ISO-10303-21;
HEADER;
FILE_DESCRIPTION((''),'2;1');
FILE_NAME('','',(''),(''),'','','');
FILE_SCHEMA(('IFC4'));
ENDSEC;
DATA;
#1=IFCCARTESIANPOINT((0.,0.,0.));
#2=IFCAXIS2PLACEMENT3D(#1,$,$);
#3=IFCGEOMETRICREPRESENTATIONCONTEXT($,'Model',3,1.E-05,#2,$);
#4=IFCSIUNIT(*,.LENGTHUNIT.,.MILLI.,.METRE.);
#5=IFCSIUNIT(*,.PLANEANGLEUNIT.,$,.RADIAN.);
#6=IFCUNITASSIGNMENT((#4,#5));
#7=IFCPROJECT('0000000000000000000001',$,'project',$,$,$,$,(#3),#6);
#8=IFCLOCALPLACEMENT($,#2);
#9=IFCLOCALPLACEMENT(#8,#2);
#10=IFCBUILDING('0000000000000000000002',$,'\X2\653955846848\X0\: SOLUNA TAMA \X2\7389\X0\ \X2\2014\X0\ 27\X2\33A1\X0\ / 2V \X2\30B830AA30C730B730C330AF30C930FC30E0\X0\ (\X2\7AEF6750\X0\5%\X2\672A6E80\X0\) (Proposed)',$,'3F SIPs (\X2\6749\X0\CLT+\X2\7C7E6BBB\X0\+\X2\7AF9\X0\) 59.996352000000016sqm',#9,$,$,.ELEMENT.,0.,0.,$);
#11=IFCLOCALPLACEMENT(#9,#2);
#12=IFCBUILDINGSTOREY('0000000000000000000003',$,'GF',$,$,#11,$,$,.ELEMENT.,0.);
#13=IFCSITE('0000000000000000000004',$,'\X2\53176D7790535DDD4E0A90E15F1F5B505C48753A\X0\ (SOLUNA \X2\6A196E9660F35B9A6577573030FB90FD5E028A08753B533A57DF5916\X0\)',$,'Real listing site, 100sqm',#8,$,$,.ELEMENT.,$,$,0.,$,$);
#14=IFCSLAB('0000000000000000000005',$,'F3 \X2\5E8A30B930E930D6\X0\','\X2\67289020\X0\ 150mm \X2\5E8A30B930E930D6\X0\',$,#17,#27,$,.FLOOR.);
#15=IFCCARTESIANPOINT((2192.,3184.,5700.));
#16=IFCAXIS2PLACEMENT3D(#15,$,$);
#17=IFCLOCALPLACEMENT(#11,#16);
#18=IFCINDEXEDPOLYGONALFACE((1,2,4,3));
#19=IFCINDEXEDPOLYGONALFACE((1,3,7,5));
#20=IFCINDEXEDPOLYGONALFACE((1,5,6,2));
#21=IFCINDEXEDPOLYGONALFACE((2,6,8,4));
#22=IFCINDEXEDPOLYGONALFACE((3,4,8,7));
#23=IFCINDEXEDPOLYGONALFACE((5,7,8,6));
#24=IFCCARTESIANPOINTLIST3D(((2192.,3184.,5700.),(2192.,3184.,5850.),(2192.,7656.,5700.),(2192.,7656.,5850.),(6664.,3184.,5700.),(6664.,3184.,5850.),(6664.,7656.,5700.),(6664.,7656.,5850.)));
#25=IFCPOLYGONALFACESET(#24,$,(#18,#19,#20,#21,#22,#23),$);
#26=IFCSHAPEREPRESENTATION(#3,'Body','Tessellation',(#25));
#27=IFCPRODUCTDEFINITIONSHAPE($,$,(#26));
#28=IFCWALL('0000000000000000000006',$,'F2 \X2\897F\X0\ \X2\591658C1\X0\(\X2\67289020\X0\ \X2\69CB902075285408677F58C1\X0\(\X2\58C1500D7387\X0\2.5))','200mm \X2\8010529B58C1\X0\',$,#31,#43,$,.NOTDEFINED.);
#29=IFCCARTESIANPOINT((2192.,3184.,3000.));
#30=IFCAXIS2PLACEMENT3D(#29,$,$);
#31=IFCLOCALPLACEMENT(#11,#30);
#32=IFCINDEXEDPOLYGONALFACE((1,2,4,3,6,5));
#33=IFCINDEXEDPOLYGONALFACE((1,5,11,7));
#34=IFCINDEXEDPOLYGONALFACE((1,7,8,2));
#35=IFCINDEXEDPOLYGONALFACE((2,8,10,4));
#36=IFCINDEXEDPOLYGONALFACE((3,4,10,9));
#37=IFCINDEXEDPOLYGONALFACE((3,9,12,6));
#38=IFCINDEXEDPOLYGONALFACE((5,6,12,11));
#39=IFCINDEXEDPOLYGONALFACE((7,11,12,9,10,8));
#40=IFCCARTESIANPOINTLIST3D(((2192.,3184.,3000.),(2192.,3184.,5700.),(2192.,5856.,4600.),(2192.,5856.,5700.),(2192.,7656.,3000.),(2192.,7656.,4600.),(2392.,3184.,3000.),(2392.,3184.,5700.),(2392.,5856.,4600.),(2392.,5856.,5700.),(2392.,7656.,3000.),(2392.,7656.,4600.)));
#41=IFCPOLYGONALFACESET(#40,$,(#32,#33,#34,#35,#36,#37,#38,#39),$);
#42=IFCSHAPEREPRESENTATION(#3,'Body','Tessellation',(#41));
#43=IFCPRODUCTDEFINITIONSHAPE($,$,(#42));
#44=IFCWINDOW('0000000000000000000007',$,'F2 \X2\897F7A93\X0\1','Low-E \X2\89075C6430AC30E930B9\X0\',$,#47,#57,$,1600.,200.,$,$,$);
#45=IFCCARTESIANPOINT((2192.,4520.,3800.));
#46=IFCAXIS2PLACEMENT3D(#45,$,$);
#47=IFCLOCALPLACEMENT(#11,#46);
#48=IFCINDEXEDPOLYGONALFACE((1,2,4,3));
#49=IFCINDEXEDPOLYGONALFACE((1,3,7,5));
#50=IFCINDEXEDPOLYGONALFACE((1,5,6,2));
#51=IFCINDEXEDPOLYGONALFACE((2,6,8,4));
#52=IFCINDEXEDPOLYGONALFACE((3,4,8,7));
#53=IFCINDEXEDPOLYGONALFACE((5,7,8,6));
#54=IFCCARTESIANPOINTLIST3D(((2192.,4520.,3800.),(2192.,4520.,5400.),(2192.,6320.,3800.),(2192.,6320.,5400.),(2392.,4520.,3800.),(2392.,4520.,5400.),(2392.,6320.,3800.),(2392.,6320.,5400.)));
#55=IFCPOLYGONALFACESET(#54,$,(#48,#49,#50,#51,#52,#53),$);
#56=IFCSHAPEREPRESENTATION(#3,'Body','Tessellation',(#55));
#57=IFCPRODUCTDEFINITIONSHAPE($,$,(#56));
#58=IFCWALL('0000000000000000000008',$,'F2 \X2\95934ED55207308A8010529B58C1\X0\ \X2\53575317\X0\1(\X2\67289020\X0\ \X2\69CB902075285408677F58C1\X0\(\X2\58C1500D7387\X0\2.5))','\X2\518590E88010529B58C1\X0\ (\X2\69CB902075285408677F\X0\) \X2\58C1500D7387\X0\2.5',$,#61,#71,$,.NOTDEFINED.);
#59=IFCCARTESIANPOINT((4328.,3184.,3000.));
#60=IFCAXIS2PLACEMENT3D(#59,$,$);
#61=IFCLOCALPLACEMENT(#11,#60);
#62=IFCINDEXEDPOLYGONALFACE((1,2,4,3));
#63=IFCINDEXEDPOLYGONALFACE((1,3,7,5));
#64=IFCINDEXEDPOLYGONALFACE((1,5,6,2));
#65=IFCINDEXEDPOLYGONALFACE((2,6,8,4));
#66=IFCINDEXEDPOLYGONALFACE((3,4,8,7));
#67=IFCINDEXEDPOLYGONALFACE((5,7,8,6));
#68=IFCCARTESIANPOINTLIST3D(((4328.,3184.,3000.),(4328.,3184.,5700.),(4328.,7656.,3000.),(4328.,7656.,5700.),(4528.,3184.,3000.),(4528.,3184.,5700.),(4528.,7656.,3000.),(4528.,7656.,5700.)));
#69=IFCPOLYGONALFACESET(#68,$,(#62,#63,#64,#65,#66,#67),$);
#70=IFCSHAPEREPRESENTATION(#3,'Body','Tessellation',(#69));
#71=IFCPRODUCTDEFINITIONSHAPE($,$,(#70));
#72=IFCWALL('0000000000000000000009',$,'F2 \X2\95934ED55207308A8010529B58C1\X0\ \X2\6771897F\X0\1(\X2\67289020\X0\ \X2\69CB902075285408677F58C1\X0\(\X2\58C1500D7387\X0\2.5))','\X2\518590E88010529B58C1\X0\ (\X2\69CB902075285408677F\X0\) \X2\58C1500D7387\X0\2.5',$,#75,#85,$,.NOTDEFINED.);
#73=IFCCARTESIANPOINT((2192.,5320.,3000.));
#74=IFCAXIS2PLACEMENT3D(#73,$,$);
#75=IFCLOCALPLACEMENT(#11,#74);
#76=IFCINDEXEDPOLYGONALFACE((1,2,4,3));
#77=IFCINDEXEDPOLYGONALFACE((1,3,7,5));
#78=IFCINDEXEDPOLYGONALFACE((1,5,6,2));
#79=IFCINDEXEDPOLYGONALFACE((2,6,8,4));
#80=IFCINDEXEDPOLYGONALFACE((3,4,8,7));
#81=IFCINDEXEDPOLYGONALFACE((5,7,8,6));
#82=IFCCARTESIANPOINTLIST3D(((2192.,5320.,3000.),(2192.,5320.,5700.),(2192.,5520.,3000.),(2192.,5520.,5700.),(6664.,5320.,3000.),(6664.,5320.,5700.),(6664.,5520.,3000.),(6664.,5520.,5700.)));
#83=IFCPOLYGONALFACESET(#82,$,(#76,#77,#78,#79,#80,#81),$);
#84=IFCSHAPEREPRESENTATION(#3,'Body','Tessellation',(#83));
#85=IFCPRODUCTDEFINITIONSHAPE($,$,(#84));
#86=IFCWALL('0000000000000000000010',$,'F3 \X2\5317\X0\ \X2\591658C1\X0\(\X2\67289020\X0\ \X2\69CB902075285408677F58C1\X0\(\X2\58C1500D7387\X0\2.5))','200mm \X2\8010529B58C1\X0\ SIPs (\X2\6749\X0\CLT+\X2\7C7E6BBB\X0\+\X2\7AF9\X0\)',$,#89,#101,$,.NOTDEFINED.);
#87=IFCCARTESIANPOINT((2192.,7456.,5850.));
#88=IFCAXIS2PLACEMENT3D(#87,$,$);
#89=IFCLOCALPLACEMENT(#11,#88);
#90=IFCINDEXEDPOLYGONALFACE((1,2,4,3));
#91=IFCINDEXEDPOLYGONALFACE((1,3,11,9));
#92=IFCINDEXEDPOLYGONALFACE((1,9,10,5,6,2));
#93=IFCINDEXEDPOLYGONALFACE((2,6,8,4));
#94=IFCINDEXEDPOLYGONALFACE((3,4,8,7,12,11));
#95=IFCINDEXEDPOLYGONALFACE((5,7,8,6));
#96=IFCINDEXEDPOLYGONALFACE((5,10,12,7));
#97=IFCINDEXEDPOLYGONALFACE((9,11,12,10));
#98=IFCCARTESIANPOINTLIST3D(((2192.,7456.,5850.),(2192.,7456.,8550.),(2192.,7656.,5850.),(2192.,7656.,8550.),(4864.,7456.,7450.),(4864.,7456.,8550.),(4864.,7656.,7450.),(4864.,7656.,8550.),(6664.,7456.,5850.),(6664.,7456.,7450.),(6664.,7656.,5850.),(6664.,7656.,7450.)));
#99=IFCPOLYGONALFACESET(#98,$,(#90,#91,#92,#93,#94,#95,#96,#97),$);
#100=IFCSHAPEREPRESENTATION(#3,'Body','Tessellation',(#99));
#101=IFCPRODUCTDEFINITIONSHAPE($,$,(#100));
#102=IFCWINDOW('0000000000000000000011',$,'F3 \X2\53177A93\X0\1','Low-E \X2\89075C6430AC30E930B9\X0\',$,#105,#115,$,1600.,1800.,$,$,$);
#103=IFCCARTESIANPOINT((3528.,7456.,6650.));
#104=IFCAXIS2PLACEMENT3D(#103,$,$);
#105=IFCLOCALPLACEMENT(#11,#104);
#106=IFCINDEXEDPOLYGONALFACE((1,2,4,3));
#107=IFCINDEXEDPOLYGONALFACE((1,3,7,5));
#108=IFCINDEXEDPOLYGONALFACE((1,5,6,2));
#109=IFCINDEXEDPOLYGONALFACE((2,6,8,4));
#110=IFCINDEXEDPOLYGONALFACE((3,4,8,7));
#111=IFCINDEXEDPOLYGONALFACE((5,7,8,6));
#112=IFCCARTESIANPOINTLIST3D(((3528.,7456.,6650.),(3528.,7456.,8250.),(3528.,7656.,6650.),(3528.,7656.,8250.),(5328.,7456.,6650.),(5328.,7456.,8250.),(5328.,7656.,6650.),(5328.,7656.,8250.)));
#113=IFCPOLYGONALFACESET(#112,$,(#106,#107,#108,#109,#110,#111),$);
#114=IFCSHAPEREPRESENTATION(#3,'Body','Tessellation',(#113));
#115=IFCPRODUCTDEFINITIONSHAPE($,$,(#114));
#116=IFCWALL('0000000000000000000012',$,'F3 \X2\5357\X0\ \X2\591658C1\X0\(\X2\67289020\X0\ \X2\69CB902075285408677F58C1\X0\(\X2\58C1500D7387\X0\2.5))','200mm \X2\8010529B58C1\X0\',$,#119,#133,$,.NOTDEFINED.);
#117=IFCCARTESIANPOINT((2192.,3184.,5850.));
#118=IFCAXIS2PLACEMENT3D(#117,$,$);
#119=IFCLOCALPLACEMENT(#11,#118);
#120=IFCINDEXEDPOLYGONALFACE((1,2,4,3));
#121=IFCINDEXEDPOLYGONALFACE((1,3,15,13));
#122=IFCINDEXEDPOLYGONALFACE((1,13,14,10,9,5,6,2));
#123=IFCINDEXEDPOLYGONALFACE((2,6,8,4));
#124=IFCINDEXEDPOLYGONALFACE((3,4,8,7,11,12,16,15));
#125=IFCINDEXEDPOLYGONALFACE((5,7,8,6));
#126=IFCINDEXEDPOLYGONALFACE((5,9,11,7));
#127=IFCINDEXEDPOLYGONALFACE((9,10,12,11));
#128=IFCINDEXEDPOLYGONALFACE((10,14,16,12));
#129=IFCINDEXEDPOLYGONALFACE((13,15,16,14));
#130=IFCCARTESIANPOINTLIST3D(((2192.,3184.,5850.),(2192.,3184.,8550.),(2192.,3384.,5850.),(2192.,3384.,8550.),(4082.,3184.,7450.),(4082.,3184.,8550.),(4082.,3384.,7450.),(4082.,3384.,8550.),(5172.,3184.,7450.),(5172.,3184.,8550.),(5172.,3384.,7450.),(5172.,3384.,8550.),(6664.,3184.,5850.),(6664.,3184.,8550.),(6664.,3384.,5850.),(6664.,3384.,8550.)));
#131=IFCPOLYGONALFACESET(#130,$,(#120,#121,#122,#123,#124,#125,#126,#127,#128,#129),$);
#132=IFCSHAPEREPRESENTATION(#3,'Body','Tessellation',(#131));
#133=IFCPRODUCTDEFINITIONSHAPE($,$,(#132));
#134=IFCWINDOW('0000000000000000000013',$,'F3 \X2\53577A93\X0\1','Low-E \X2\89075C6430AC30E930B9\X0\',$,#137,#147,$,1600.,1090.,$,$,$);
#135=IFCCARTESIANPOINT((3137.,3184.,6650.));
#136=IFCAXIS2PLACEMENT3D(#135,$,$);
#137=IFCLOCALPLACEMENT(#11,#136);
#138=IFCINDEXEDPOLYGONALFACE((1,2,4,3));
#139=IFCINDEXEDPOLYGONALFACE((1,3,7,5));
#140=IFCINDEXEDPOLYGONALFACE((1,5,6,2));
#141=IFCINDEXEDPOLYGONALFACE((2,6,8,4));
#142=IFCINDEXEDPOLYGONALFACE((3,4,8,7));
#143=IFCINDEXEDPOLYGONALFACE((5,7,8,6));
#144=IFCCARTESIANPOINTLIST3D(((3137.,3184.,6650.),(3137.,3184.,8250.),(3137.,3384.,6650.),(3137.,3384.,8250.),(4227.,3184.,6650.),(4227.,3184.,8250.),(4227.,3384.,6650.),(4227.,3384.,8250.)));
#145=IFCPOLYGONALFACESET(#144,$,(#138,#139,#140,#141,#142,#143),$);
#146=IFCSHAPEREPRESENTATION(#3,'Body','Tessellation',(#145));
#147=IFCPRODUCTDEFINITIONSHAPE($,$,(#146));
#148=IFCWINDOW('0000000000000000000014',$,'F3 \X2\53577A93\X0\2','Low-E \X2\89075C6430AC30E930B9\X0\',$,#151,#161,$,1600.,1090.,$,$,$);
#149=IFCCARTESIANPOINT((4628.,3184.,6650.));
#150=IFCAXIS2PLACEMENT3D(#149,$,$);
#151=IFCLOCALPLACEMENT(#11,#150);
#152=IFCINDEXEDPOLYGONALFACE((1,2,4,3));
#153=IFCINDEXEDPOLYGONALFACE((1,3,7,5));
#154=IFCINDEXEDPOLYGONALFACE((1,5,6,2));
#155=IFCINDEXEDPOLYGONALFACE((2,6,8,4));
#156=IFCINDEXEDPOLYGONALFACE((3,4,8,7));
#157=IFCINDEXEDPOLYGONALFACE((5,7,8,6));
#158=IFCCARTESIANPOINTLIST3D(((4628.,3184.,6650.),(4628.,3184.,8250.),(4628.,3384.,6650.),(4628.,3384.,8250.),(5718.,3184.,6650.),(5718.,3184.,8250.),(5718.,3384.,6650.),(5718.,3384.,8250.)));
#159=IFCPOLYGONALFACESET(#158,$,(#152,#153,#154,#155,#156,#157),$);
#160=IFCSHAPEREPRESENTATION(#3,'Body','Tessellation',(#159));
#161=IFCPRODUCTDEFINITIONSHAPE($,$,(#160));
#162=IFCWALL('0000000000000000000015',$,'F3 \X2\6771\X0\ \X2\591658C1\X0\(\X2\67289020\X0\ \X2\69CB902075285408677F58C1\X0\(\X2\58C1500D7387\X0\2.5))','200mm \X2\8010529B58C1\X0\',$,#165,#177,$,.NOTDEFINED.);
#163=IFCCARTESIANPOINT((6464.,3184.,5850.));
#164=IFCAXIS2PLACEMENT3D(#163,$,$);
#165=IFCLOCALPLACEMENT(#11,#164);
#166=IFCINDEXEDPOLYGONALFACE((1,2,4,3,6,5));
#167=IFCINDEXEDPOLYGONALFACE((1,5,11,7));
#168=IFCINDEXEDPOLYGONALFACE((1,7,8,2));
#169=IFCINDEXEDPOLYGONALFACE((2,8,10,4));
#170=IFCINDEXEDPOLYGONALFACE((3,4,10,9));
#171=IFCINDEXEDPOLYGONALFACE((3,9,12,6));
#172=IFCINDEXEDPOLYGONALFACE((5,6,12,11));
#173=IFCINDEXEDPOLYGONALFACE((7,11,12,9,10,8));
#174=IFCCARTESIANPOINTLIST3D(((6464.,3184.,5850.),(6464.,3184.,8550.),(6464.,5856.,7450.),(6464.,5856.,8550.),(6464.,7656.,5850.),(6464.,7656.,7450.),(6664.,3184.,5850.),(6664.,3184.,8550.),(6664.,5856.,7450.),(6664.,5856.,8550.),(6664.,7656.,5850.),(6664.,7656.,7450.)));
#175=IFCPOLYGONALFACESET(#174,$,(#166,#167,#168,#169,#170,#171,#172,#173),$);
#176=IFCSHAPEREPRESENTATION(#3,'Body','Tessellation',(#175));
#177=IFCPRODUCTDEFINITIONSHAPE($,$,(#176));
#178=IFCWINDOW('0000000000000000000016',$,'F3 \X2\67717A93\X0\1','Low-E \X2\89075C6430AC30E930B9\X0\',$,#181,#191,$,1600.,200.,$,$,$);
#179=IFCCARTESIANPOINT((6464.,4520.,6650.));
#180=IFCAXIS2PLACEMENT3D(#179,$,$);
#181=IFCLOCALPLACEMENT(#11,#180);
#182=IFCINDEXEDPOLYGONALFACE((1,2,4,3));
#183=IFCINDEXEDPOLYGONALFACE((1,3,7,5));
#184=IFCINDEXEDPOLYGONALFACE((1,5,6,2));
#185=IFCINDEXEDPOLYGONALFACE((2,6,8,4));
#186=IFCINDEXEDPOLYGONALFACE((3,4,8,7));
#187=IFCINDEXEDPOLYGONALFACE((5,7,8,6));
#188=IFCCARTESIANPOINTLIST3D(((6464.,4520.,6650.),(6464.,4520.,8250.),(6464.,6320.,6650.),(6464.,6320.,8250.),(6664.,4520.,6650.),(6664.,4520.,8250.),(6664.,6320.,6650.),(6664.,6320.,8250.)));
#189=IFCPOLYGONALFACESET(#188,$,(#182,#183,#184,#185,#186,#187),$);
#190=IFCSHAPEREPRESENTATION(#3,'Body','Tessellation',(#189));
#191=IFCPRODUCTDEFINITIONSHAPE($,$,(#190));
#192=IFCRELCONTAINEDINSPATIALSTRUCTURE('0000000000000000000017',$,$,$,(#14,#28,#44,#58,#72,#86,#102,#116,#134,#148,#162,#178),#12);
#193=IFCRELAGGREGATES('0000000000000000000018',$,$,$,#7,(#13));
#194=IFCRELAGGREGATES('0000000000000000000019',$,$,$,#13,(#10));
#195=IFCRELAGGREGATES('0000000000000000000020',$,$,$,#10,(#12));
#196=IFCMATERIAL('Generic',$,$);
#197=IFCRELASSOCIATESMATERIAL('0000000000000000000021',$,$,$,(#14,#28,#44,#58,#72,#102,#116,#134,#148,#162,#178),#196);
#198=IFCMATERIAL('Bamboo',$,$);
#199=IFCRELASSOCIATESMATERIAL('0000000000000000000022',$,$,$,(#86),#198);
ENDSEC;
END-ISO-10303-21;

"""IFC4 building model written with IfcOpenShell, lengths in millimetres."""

from ifc_helpers import new_model, si_unit, frame, frame_2d, origin, place, context, project, spatial, rectangle, extrude, material, element, fill, save


model = new_model("IFC4")

# Units and contexts
model_context = context("Model", 3, precision=1e-05, world=origin())
ifc_project = project(units=[si_unit("LENGTHUNIT", "METRE", prefix="MILLI"), si_unit("PLANEANGLEUNIT", "RADIAN")], contexts=[model_context])

# Site, building, storey
site_placement = place(None, origin())
site = spatial("IfcSite", under=ifc_project, at=site_placement, Name="北海道川上郡弟子屈町 (SOLUNA 標準想定敷地・都市計画区域外)", ObjectType="Real listing site, 100sqm", CompositionType="ELEMENT", RefElevation=0.0)
building_placement = place(site_placement, origin())
building = spatial("IfcBuilding", under=site, at=building_placement, Name="改善案: SOLUNA TAMA 玉 — 27㎡ / 2V ジオデシックドーム (端材5%未満) (Proposed)", ObjectType="3F SIPs (杉CLT+籾殻+竹) 59.996352000000016sqm", CompositionType="ELEMENT", ElevationOfRefHeight=0.0, ElevationOfTerrain=0.0)
storey_placement = place(building_placement, origin())
storey = spatial("IfcBuildingStorey", under=building, at=storey_placement, Name="GF", CompositionType="ELEMENT", Elevation=0.0)

# Slab
ifc_material_1 = material(Name="Generic")
slab_placement = place(storey_placement, frame((2192.0, 3184.0, 5700.0)))
element("IfcSlab", 1, at=slab_placement, inside=storey, material=ifc_material_1, Name="F3 床スラブ", Description="木造 150mm 床スラブ", PredefinedType="FLOOR", context=model_context, shape_type="SweptSolid", body=[
    extrude(rectangle(XDim=4472.0, YDim=4472.0, at=frame_2d((2236.0, 2236.0))), frame((2192.0, 3184.0, 5700.0)), (0.0, 0.0, 1.0), 150.0),
])

# Wall, opening, window
wall_1_placement = place(storey_placement, frame((2192.0, 3184.0, 3000.0)))
wall_1 = element("IfcWall", 2, at=wall_1_placement, inside=storey, material=ifc_material_1, Name="F2 西 外壁(木造 構造用合板壁(壁倍率2.5))", Description="200mm 耐力壁", PredefinedType="NOTDEFINED", context=model_context, shape_type="SweptSolid", body=[
    extrude(rectangle(XDim=200.0, YDim=4472.0, at=frame_2d((100.0, 2236.0))), frame((2192.0, 3184.0, 3000.0)), (0.0, 0.0, 1.0), 2700.0),
])
opening_1_placement = place(storey_placement, frame((2192.0, 4520.0, 3800.0)))
opening_1 = element("IfcOpeningElement", 3, at=opening_1_placement, cuts=wall_1, PredefinedType="NOTDEFINED", context=model_context, shape_type="SweptSolid", body=[
    extrude(rectangle(XDim=200.0, YDim=1800.0, at=frame_2d((100.0, 900.0))), frame((2192.0, 4520.0, 3800.0)), (0.0, 0.0, 1.0), 1600.0),
])
window_1_placement = place(storey_placement, frame((2192.0, 4520.0, 3800.0)))
window_1 = element("IfcWindow", 4, at=window_1_placement, inside=storey, material=ifc_material_1, Name="F2 西窓1", Description="Low-E 複層ガラス", OverallHeight=1600.0, OverallWidth=200.0, context=model_context, shape_type="SweptSolid", body=[
    extrude(rectangle(XDim=200.0, YDim=1800.0, at=frame_2d((100.0, 900.0))), frame((2192.0, 4520.0, 3800.0)), (0.0, 0.0, 1.0), 1600.0),
])
fill(opening_1, window_1)

# Walls
wall_2_placement = place(storey_placement, frame((4328.0, 3184.0, 3000.0)))
element("IfcWall", 5, at=wall_2_placement, inside=storey, material=ifc_material_1, Name="F2 間仕切り耐力壁 南北1(木造 構造用合板壁(壁倍率2.5))", Description="内部耐力壁 (構造用合板) 壁倍率2.5", PredefinedType="NOTDEFINED", context=model_context, shape_type="SweptSolid", body=[
    extrude(rectangle(XDim=200.0, YDim=4472.0, at=frame_2d((100.0, 2236.0))), frame((4328.0, 3184.0, 3000.0)), (0.0, 0.0, 1.0), 2700.0),
])
wall_3_placement = place(storey_placement, frame((2192.0, 5320.0, 3000.0)))
element("IfcWall", 6, at=wall_3_placement, inside=storey, material=ifc_material_1, Name="F2 間仕切り耐力壁 東西1(木造 構造用合板壁(壁倍率2.5))", Description="内部耐力壁 (構造用合板) 壁倍率2.5", PredefinedType="NOTDEFINED", context=model_context, shape_type="SweptSolid", body=[
    extrude(rectangle(XDim=4472.0, YDim=200.0, at=frame_2d((2236.0, 100.0))), frame((2192.0, 5320.0, 3000.0)), (0.0, 0.0, 1.0), 2700.0),
])

# Wall, opening, window
ifc_material_2 = material(Name="Bamboo")
wall_4_placement = place(storey_placement, frame((2192.0, 7456.0, 5850.0)))
wall_4 = element("IfcWall", 7, at=wall_4_placement, inside=storey, material=ifc_material_2, Name="F3 北 外壁(木造 構造用合板壁(壁倍率2.5))", Description="200mm 耐力壁 SIPs (杉CLT+籾殻+竹)", PredefinedType="NOTDEFINED", context=model_context, shape_type="SweptSolid", body=[
    extrude(rectangle(XDim=4472.0, YDim=200.0, at=frame_2d((2236.0, 100.0))), frame((2192.0, 7456.0, 5850.0)), (0.0, 0.0, 1.0), 2700.0),
])
opening_2_placement = place(storey_placement, frame((3528.0, 7456.0, 6650.0)))
opening_2 = element("IfcOpeningElement", 8, at=opening_2_placement, cuts=wall_4, PredefinedType="NOTDEFINED", context=model_context, shape_type="SweptSolid", body=[
    extrude(rectangle(XDim=1800.0, YDim=200.0, at=frame_2d((900.0, 100.0))), frame((3528.0, 7456.0, 6650.0)), (0.0, 0.0, 1.0), 1600.0),
])
window_2_placement = place(storey_placement, frame((3528.0, 7456.0, 6650.0)))
window_2 = element("IfcWindow", 9, at=window_2_placement, inside=storey, material=ifc_material_1, Name="F3 北窓1", Description="Low-E 複層ガラス", OverallHeight=1600.0, OverallWidth=1800.0, context=model_context, shape_type="SweptSolid", body=[
    extrude(rectangle(XDim=1800.0, YDim=200.0, at=frame_2d((900.0, 100.0))), frame((3528.0, 7456.0, 6650.0)), (0.0, 0.0, 1.0), 1600.0),
])
fill(opening_2, window_2)

# Wall, openings, windows
wall_5_placement = place(storey_placement, frame((2192.0, 3184.0, 5850.0)))
wall_5 = element("IfcWall", 10, at=wall_5_placement, inside=storey, material=ifc_material_1, Name="F3 南 外壁(木造 構造用合板壁(壁倍率2.5))", Description="200mm 耐力壁", PredefinedType="NOTDEFINED", context=model_context, shape_type="SweptSolid", body=[
    extrude(rectangle(XDim=4472.0, YDim=200.0, at=frame_2d((2236.0, 100.0))), frame((2192.0, 3184.0, 5850.0)), (0.0, 0.0, 1.0), 2700.0),
])
opening_3_placement = place(storey_placement, frame((3137.0, 3184.0, 6650.0)))
opening_3 = element("IfcOpeningElement", 11, at=opening_3_placement, cuts=wall_5, PredefinedType="NOTDEFINED", context=model_context, shape_type="SweptSolid", body=[
    extrude(rectangle(XDim=1090.0, YDim=200.0, at=frame_2d((545.0, 100.0))), frame((3137.0, 3184.0, 6650.0)), (0.0, 0.0, 1.0), 1600.0),
])
opening_4_placement = place(storey_placement, frame((4628.0, 3184.0, 6650.0)))
opening_4 = element("IfcOpeningElement", 12, at=opening_4_placement, cuts=wall_5, PredefinedType="NOTDEFINED", context=model_context, shape_type="SweptSolid", body=[
    extrude(rectangle(XDim=1090.0, YDim=200.0, at=frame_2d((545.0, 100.0))), frame((4628.0, 3184.0, 6650.0)), (0.0, 0.0, 1.0), 1600.0),
])
window_3_placement = place(storey_placement, frame((3137.0, 3184.0, 6650.0)))
window_3 = element("IfcWindow", 13, at=window_3_placement, inside=storey, material=ifc_material_1, Name="F3 南窓1", Description="Low-E 複層ガラス", OverallHeight=1600.0, OverallWidth=1090.0, context=model_context, shape_type="SweptSolid", body=[
    extrude(rectangle(XDim=1090.0, YDim=200.0, at=frame_2d((545.0, 100.0))), frame((3137.0, 3184.0, 6650.0)), (0.0, 0.0, 1.0), 1600.0),
])
fill(opening_3, window_3)
window_4_placement = place(storey_placement, frame((4628.0, 3184.0, 6650.0)))
window_4 = element("IfcWindow", 14, at=window_4_placement, inside=storey, material=ifc_material_1, Name="F3 南窓2", Description="Low-E 複層ガラス", OverallHeight=1600.0, OverallWidth=1090.0, context=model_context, shape_type="SweptSolid", body=[
    extrude(rectangle(XDim=1090.0, YDim=200.0, at=frame_2d((545.0, 100.0))), frame((4628.0, 3184.0, 6650.0)), (0.0, 0.0, 1.0), 1600.0),
])
fill(opening_4, window_4)

# Wall, opening, window
wall_6_placement = place(storey_placement, frame((6464.0, 3184.0, 5850.0)))
wall_6 = element("IfcWall", 15, at=wall_6_placement, inside=storey, material=ifc_material_1, Name="F3 東 外壁(木造 構造用合板壁(壁倍率2.5))", Description="200mm 耐力壁", PredefinedType="NOTDEFINED", context=model_context, shape_type="SweptSolid", body=[
    extrude(rectangle(XDim=200.0, YDim=4472.0, at=frame_2d((100.0, 2236.0))), frame((6464.0, 3184.0, 5850.0)), (0.0, 0.0, 1.0), 2700.0),
])
opening_5_placement = place(storey_placement, frame((6464.0, 4520.0, 6650.0)))
opening_5 = element("IfcOpeningElement", 16, at=opening_5_placement, cuts=wall_6, PredefinedType="NOTDEFINED", context=model_context, shape_type="SweptSolid", body=[
    extrude(rectangle(XDim=200.0, YDim=1800.0, at=frame_2d((100.0, 900.0))), frame((6464.0, 4520.0, 6650.0)), (0.0, 0.0, 1.0), 1600.0),
])
window_5_placement = place(storey_placement, frame((6464.0, 4520.0, 6650.0)))
window_5 = element("IfcWindow", 17, at=window_5_placement, inside=storey, material=ifc_material_1, Name="F3 東窓1", Description="Low-E 複層ガラス", OverallHeight=1600.0, OverallWidth=200.0, context=model_context, shape_type="SweptSolid", body=[
    extrude(rectangle(XDim=200.0, YDim=1800.0, at=frame_2d((100.0, 900.0))), frame((6464.0, 4520.0, 6650.0)), (0.0, 0.0, 1.0), 1600.0),
])
fill(opening_5, window_5)

save(model, "model.ifc")
